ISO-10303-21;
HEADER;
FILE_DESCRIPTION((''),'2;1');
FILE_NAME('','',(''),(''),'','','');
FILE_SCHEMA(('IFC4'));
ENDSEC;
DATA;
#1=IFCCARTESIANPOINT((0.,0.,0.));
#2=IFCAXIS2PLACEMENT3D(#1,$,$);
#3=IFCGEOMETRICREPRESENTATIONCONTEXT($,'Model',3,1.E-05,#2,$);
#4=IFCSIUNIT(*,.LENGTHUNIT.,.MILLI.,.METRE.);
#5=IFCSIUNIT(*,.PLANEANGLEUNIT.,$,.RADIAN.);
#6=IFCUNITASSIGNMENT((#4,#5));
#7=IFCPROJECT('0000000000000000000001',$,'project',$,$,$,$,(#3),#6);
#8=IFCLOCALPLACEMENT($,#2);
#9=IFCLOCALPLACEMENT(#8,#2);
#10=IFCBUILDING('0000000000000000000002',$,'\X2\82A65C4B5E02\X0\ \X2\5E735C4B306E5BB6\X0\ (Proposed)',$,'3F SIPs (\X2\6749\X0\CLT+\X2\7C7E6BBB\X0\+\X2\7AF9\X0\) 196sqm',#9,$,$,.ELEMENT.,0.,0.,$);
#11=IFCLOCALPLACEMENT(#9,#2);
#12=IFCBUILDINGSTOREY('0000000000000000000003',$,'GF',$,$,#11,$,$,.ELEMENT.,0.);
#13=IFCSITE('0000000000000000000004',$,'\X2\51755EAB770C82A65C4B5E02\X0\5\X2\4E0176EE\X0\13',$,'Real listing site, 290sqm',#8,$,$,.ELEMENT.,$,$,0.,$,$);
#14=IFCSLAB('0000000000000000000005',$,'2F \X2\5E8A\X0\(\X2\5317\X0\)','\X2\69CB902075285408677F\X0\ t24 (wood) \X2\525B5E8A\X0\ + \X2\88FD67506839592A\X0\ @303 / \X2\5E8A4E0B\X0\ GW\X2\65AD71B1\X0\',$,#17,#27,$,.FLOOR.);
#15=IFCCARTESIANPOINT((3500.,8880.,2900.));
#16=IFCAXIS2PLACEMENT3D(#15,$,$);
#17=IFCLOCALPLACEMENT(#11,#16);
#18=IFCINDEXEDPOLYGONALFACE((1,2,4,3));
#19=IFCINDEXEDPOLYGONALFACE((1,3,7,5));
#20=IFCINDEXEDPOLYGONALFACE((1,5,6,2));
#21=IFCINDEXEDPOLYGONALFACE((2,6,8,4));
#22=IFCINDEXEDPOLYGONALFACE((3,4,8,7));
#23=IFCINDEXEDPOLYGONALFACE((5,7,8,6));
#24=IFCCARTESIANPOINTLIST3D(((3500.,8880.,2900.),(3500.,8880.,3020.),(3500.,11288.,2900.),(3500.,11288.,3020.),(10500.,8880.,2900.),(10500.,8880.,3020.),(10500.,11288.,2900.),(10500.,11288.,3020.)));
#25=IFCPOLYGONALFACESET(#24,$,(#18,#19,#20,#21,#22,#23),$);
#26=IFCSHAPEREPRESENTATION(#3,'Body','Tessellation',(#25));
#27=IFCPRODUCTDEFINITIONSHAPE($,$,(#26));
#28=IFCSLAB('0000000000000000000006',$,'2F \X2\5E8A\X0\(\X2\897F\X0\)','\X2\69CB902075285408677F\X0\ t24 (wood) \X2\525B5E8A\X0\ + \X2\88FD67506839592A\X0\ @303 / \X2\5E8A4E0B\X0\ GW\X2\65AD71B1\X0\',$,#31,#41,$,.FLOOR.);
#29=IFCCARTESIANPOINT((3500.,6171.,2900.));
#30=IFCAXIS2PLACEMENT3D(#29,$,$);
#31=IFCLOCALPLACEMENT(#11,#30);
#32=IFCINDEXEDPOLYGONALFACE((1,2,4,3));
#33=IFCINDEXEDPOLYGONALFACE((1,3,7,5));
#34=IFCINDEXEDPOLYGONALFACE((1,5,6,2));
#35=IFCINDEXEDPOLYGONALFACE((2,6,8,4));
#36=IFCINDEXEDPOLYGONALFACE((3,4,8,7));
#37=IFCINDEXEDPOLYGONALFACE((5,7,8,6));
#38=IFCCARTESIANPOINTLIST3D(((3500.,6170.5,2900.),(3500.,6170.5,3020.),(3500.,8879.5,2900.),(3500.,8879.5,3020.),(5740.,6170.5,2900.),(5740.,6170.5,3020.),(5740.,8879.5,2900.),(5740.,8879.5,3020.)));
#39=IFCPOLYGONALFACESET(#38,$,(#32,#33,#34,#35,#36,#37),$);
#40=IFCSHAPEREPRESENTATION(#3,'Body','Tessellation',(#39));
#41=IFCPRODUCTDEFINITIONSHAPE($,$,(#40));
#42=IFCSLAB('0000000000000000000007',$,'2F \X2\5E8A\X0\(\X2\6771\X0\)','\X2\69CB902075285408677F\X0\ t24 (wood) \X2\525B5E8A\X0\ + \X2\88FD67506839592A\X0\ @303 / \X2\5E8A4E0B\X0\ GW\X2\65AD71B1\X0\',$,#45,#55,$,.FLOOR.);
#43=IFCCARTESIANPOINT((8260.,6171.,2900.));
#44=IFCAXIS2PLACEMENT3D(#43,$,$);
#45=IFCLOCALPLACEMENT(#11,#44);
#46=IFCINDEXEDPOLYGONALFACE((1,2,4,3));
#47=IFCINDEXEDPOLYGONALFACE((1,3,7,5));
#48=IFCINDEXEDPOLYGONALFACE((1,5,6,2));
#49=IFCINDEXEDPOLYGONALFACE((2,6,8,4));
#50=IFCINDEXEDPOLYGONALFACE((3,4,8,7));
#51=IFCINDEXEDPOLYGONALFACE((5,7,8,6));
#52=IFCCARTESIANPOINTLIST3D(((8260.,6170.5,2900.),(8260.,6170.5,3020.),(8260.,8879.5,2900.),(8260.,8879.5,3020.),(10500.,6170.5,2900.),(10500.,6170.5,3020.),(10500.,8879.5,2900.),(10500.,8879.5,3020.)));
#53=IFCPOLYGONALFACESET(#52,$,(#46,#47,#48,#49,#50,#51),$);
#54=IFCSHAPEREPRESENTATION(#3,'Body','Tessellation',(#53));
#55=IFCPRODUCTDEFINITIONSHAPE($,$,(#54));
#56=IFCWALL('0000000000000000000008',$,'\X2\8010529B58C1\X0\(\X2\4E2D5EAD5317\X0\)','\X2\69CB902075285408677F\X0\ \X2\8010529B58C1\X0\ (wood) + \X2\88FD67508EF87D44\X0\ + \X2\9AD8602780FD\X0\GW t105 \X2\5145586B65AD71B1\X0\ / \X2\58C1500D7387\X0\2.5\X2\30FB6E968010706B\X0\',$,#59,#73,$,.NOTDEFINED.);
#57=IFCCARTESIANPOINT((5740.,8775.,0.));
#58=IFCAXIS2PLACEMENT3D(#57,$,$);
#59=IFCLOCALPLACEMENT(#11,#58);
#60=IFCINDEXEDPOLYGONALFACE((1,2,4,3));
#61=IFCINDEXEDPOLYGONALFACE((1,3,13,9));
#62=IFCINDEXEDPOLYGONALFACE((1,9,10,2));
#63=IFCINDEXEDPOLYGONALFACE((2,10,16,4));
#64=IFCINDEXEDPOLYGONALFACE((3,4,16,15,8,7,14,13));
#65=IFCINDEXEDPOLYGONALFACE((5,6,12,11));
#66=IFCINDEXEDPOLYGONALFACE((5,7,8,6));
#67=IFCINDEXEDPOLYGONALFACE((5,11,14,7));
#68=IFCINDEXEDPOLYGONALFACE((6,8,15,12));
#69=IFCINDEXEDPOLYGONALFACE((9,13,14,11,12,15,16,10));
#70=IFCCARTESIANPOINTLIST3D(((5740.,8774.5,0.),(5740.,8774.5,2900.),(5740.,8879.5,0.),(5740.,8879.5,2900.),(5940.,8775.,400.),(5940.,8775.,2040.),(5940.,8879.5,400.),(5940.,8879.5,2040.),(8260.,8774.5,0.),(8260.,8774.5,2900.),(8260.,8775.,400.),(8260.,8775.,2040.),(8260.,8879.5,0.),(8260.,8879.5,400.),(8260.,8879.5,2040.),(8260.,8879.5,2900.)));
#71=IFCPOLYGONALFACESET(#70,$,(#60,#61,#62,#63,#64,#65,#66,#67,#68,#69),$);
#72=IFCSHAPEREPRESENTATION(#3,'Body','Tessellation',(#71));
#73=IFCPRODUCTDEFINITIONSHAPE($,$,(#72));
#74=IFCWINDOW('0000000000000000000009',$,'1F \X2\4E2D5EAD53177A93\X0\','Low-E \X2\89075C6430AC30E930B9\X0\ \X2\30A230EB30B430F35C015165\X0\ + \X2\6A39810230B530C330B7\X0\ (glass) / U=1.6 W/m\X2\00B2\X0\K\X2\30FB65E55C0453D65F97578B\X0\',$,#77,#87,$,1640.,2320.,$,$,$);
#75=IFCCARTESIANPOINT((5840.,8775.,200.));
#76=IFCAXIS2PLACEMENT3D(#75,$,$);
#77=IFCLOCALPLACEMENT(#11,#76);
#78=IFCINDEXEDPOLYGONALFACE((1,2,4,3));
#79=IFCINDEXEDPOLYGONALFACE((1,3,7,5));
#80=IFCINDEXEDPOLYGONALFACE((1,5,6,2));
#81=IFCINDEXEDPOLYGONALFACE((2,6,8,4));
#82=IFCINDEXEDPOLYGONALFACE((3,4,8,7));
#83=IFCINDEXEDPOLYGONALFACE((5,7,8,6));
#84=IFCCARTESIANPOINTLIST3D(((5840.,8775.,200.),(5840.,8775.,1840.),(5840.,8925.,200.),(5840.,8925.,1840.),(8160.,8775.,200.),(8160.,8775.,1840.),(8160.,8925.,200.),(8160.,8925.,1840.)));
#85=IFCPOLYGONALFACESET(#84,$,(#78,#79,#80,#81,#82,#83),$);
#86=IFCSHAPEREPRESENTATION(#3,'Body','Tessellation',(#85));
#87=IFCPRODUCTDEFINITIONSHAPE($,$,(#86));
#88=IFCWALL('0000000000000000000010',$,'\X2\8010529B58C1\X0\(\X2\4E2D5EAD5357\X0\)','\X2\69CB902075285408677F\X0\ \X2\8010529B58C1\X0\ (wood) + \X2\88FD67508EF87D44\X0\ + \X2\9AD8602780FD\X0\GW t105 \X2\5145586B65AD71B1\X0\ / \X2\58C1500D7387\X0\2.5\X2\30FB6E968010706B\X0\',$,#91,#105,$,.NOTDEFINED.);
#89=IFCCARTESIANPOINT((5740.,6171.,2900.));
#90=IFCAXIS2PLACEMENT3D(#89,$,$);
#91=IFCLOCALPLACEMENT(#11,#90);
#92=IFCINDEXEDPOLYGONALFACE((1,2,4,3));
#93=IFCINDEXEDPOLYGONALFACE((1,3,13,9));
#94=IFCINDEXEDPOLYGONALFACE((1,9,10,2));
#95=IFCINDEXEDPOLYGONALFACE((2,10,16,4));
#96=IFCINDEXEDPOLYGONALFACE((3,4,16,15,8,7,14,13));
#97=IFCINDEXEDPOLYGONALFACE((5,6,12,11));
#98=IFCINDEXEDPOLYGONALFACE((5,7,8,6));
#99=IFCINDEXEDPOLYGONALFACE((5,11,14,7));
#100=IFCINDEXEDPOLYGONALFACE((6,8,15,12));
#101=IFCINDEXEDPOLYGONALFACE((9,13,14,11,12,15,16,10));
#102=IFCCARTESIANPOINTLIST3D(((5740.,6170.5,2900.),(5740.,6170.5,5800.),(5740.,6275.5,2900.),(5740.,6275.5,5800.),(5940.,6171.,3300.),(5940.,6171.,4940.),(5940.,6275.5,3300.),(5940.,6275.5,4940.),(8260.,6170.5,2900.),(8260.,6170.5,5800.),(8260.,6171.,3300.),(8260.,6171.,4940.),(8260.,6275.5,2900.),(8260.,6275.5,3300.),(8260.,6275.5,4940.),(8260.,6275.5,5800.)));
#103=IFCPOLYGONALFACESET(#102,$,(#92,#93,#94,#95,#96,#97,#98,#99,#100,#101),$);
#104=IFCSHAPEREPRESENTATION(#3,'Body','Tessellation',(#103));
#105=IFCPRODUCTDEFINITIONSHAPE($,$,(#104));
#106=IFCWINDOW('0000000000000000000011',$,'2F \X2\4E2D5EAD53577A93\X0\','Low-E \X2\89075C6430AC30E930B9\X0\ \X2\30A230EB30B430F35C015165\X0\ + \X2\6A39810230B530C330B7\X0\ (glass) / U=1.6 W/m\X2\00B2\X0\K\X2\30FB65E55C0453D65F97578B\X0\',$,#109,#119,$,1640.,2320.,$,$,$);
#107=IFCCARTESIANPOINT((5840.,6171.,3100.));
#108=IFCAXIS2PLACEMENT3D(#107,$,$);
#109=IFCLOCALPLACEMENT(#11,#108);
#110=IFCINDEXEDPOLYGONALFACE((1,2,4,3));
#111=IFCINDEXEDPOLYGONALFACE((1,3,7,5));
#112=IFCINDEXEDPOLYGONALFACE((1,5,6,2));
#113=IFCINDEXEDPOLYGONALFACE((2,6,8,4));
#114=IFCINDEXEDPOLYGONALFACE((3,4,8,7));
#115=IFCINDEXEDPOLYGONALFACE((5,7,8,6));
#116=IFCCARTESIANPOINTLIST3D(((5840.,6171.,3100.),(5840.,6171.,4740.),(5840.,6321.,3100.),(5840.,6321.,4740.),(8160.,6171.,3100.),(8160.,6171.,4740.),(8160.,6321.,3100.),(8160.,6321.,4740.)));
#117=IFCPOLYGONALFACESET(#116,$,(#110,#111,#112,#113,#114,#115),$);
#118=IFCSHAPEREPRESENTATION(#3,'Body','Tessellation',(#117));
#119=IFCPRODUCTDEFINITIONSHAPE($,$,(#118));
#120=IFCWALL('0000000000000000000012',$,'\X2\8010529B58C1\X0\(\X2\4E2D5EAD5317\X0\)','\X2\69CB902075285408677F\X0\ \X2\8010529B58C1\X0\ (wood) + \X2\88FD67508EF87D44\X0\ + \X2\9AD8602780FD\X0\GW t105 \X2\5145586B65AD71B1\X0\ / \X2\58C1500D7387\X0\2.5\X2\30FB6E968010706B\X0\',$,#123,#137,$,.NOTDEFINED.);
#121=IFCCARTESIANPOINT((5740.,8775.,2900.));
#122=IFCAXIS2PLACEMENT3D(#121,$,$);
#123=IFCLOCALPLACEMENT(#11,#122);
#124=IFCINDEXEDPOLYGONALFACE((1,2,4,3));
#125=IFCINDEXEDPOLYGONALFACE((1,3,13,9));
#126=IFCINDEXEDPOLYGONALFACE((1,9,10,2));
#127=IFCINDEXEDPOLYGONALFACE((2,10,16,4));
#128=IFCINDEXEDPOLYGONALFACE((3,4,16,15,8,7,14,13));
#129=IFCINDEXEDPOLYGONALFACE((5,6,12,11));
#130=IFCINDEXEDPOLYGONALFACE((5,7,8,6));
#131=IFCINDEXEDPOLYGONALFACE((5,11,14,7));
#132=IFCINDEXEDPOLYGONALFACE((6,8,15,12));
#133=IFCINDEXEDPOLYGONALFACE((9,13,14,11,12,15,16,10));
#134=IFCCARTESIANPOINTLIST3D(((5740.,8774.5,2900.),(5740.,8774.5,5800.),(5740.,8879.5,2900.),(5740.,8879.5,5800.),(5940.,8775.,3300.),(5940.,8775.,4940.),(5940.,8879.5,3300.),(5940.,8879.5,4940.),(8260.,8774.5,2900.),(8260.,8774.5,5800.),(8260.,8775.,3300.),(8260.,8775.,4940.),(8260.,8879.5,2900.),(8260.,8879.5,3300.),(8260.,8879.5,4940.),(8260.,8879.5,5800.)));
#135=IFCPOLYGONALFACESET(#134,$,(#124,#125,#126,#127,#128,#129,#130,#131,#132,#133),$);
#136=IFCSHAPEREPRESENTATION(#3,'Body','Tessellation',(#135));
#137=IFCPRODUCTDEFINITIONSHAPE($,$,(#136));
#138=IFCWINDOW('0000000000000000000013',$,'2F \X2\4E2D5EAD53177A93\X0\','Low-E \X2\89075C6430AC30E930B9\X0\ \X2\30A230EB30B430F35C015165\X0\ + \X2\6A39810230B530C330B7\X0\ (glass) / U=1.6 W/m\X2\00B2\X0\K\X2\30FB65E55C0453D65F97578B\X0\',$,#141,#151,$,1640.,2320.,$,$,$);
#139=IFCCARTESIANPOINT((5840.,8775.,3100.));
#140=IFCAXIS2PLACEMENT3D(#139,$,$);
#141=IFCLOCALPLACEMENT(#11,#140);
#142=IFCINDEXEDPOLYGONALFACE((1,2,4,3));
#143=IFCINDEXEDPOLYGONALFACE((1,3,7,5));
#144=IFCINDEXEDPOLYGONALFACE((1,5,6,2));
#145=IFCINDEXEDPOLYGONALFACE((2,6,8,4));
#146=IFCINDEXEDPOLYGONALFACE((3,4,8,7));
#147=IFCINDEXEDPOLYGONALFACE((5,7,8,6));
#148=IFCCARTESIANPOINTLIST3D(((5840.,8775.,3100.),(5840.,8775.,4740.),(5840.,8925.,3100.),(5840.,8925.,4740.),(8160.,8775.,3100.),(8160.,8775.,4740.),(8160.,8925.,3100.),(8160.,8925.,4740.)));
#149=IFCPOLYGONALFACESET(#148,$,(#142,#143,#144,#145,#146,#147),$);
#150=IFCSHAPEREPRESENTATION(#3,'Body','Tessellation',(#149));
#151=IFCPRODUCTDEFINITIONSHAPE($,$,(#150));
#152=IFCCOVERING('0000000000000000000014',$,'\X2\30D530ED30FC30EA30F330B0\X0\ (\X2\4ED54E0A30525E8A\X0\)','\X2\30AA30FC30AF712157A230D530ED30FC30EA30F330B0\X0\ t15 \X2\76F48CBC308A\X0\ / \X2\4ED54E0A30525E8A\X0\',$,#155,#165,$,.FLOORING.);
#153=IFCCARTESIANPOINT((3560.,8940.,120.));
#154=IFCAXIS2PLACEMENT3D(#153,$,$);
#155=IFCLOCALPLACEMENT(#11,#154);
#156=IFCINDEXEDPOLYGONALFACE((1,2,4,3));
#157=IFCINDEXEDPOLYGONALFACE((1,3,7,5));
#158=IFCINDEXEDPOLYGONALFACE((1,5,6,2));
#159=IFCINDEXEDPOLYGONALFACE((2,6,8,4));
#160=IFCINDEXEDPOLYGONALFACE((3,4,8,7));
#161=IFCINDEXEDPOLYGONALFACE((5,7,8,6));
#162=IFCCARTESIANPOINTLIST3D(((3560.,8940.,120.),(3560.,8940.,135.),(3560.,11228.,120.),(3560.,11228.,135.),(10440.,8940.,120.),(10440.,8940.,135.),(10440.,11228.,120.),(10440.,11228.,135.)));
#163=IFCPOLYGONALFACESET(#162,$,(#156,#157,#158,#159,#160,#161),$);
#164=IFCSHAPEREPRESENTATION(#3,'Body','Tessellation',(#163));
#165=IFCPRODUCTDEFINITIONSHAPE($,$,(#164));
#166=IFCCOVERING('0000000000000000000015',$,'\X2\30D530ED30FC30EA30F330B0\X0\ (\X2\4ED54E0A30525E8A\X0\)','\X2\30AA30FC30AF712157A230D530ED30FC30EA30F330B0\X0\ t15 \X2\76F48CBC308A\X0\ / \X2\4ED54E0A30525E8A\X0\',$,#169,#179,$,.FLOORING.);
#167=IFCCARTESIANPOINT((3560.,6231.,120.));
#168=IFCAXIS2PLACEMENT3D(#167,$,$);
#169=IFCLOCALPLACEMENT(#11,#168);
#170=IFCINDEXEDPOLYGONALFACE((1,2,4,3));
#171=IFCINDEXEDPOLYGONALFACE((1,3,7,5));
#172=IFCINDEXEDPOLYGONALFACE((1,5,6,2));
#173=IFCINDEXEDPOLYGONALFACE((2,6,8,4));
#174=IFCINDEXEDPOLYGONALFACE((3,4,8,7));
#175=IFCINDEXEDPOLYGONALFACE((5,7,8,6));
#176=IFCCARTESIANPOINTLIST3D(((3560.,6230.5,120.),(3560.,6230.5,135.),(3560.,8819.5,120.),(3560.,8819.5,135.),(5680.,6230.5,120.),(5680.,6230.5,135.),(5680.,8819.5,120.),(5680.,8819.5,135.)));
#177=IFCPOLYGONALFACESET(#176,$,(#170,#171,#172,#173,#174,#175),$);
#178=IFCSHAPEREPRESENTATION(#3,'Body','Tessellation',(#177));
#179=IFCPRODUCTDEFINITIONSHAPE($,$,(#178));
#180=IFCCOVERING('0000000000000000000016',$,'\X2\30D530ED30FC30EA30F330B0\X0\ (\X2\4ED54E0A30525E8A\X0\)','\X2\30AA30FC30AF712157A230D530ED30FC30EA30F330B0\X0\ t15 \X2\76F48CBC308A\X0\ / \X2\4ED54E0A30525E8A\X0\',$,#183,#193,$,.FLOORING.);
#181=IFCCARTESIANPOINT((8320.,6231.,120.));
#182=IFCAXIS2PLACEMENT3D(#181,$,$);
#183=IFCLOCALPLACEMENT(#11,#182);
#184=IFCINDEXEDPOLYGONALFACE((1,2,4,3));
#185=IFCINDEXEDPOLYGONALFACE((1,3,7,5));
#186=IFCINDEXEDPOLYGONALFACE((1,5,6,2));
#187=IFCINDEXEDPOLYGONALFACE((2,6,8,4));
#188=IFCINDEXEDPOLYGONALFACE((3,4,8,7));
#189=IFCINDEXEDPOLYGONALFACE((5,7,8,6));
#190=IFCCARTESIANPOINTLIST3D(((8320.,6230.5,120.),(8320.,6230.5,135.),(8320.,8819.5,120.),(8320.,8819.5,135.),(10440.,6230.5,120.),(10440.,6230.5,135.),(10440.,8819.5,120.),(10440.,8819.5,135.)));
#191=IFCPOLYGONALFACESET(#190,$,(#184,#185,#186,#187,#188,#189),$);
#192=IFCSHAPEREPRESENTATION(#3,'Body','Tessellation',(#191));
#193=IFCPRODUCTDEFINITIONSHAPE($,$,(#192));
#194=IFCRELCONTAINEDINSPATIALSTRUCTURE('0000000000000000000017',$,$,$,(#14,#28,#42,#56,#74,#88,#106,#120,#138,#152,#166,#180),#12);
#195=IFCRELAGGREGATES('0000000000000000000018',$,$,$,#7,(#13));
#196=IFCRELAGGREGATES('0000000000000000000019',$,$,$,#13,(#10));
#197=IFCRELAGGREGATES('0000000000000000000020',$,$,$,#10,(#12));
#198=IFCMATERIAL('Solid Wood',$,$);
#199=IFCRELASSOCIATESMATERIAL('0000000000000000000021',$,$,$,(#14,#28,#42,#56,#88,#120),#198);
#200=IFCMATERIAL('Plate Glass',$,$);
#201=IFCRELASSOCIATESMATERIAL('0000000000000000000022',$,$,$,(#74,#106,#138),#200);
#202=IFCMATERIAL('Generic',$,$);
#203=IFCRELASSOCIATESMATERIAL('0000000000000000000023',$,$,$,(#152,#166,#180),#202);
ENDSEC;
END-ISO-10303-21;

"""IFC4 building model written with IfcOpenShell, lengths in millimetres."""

from ifc_helpers import new_model, si_unit, frame, frame_2d, origin, place, context, project, spatial, rectangle, extrude, material, element, fill, save


model = new_model("IFC4")

# Units and contexts
model_context = context("Model", 3, precision=1e-05, world=origin())
ifc_project = project(units=[si_unit("LENGTHUNIT", "METRE", prefix="MILLI"), si_unit("PLANEANGLEUNIT", "RADIAN")], contexts=[model_context])

# Site, building, storey
site_placement = place(None, origin())
site = spatial("IfcSite", under=ifc_project, at=site_placement, Name="兵庫県芦屋市5丁目13", ObjectType="Real listing site, 290sqm", CompositionType="ELEMENT", RefElevation=0.0)
building_placement = place(site_placement, origin())
building = spatial("IfcBuilding", under=site, at=building_placement, Name="芦屋市 平屋の家 (Proposed)", ObjectType="3F SIPs (杉CLT+籾殻+竹) 196sqm", CompositionType="ELEMENT", ElevationOfRefHeight=0.0, ElevationOfTerrain=0.0)
storey_placement = place(building_placement, origin())
storey = spatial("IfcBuildingStorey", under=building, at=storey_placement, Name="GF", CompositionType="ELEMENT", Elevation=0.0)

# Slabs
ifc_material_1 = material(Name="Solid Wood")
slab_1_placement = place(storey_placement, frame((3500.0, 8880.0, 2900.0)))
element("IfcSlab", 1, at=slab_1_placement, inside=storey, material=ifc_material_1, Name="2F 床(北)", Description="構造用合板 t24 (wood) 剛床 + 製材根太 @303 / 床下 GW断熱", PredefinedType="FLOOR", context=model_context, shape_type="SweptSolid", body=[
    extrude(rectangle(XDim=7000.0, YDim=2408.0, at=frame_2d((3500.0, 1204.0))), frame((3500.0, 8880.0, 2900.0)), (0.0, 0.0, 1.0), 120.0),
])
slab_2_placement = place(storey_placement, frame((3500.0, 6171.0, 2900.0)))
element("IfcSlab", 2, at=slab_2_placement, inside=storey, material=ifc_material_1, Name="2F 床(西)", Description="構造用合板 t24 (wood) 剛床 + 製材根太 @303 / 床下 GW断熱", PredefinedType="FLOOR", context=model_context, shape_type="SweptSolid", body=[
    extrude(rectangle(XDim=2240.0, YDim=2709.0, at=frame_2d((1120.0, 1354.0))), frame((3500.0, 6171.0, 2900.0)), (0.0, 0.0, 1.0), 120.0),
])
slab_3_placement = place(storey_placement, frame((8260.0, 6171.0, 2900.0)))
element("IfcSlab", 3, at=slab_3_placement, inside=storey, material=ifc_material_1, Name="2F 床(東)", Description="構造用合板 t24 (wood) 剛床 + 製材根太 @303 / 床下 GW断熱", PredefinedType="FLOOR", context=model_context, shape_type="SweptSolid", body=[
    extrude(rectangle(XDim=2240.0, YDim=2709.0, at=frame_2d((1120.0, 1354.0))), frame((8260.0, 6171.0, 2900.0)), (0.0, 0.0, 1.0), 120.0),
])

# Wall, opening, window
wall_1_placement = place(storey_placement, frame((5740.0, 8775.0, 0.0)))
wall_1 = element("IfcWall", 4, at=wall_1_placement, inside=storey, material=ifc_material_1, Name="耐力壁(中庭北)", Description="構造用合板 耐力壁 (wood) + 製材軸組 + 高性能GW t105 充填断熱 / 壁倍率2.5・準耐火", PredefinedType="NOTDEFINED", context=model_context, shape_type="SweptSolid", body=[
    extrude(rectangle(XDim=2520.0, YDim=105.0, at=frame_2d((1260.0, 52.0))), frame((5740.0, 8775.0, 0.0)), (0.0, 0.0, 1.0), 2900.0),
])
opening_1_placement = place(storey_placement, frame((5840.0, 8775.0, 200.0)))
opening_1 = element("IfcOpeningElement", 5, at=opening_1_placement, cuts=wall_1, PredefinedType="NOTDEFINED", context=model_context, shape_type="SweptSolid", body=[
    extrude(rectangle(XDim=2320.0, YDim=150.0, at=frame_2d((1160.0, 75.0))), frame((5840.0, 8775.0, 200.0)), (0.0, 0.0, 1.0), 1640.0),
])
ifc_material_2 = material(Name="Plate Glass")
window_1_placement = place(storey_placement, frame((5840.0, 8775.0, 200.0)))
window_1 = element("IfcWindow", 6, at=window_1_placement, inside=storey, material=ifc_material_2, Name="1F 中庭北窓", Description="Low-E 複層ガラス アルゴン封入 + 樹脂サッシ (glass) / U=1.6 W/m²K・日射取得型", OverallHeight=1640.0, OverallWidth=2320.0, context=model_context, shape_type="SweptSolid", body=[
    extrude(rectangle(XDim=2320.0, YDim=150.0, at=frame_2d((1160.0, 75.0))), frame((5840.0, 8775.0, 200.0)), (0.0, 0.0, 1.0), 1640.0),
])
fill(opening_1, window_1)

# Walls, openings, windows
wall_2_placement = place(storey_placement, frame((5740.0, 6171.0, 2900.0)))
wall_2 = element("IfcWall", 7, at=wall_2_placement, inside=storey, material=ifc_material_1, Name="耐力壁(中庭南)", Description="構造用合板 耐力壁 (wood) + 製材軸組 + 高性能GW t105 充填断熱 / 壁倍率2.5・準耐火", PredefinedType="NOTDEFINED", context=model_context, shape_type="SweptSolid", body=[
    extrude(rectangle(XDim=2520.0, YDim=105.0, at=frame_2d((1260.0, 52.0))), frame((5740.0, 6171.0, 2900.0)), (0.0, 0.0, 1.0), 2900.0),
])
opening_2_placement = place(storey_placement, frame((5840.0, 6171.0, 3100.0)))
opening_2 = element("IfcOpeningElement", 8, at=opening_2_placement, cuts=wall_2, PredefinedType="NOTDEFINED", context=model_context, shape_type="SweptSolid", body=[
    extrude(rectangle(XDim=2320.0, YDim=150.0, at=frame_2d((1160.0, 75.0))), frame((5840.0, 6171.0, 3100.0)), (0.0, 0.0, 1.0), 1640.0),
])
window_2_placement = place(storey_placement, frame((5840.0, 6171.0, 3100.0)))
window_2 = element("IfcWindow", 9, at=window_2_placement, inside=storey, material=ifc_material_2, Name="2F 中庭南窓", Description="Low-E 複層ガラス アルゴン封入 + 樹脂サッシ (glass) / U=1.6 W/m²K・日射取得型", OverallHeight=1640.0, OverallWidth=2320.0, context=model_context, shape_type="SweptSolid", body=[
    extrude(rectangle(XDim=2320.0, YDim=150.0, at=frame_2d((1160.0, 75.0))), frame((5840.0, 6171.0, 3100.0)), (0.0, 0.0, 1.0), 1640.0),
])
fill(opening_2, window_2)
wall_3_placement = place(storey_placement, frame((5740.0, 8775.0, 2900.0)))
wall_3 = element("IfcWall", 10, at=wall_3_placement, inside=storey, material=ifc_material_1, Name="耐力壁(中庭北)", Description="構造用合板 耐力壁 (wood) + 製材軸組 + 高性能GW t105 充填断熱 / 壁倍率2.5・準耐火", PredefinedType="NOTDEFINED", context=model_context, shape_type="SweptSolid", body=[
    extrude(rectangle(XDim=2520.0, YDim=105.0, at=frame_2d((1260.0, 52.0))), frame((5740.0, 8775.0, 2900.0)), (0.0, 0.0, 1.0), 2900.0),
])
opening_3_placement = place(storey_placement, frame((5840.0, 8775.0, 3100.0)))
opening_3 = element("IfcOpeningElement", 11, at=opening_3_placement, cuts=wall_3, PredefinedType="NOTDEFINED", context=model_context, shape_type="SweptSolid", body=[
    extrude(rectangle(XDim=2320.0, YDim=150.0, at=frame_2d((1160.0, 75.0))), frame((5840.0, 8775.0, 3100.0)), (0.0, 0.0, 1.0), 1640.0),
])
window_3_placement = place(storey_placement, frame((5840.0, 8775.0, 3100.0)))
window_3 = element("IfcWindow", 12, at=window_3_placement, inside=storey, material=ifc_material_2, Name="2F 中庭北窓", Description="Low-E 複層ガラス アルゴン封入 + 樹脂サッシ (glass) / U=1.6 W/m²K・日射取得型", OverallHeight=1640.0, OverallWidth=2320.0, context=model_context, shape_type="SweptSolid", body=[
    extrude(rectangle(XDim=2320.0, YDim=150.0, at=frame_2d((1160.0, 75.0))), frame((5840.0, 8775.0, 3100.0)), (0.0, 0.0, 1.0), 1640.0),
])
fill(opening_3, window_3)

# Coverings
ifc_material_3 = material(Name="Generic")
covering_1_placement = place(storey_placement, frame((3560.0, 8940.0, 120.0)))
element("IfcCovering", 13, at=covering_1_placement, inside=storey, material=ifc_material_3, Name="フローリング (仕上げ床)", Description="オーク無垢フローリング t15 直貼り / 仕上げ床", PredefinedType="FLOORING", context=model_context, shape_type="SweptSolid", body=[
    extrude(rectangle(XDim=6880.0, YDim=2288.0, at=frame_2d((3440.0, 1144.0))), frame((3560.0, 8940.0, 120.0)), (0.0, 0.0, 1.0), 15.0),
])
covering_2_placement = place(storey_placement, frame((3560.0, 6231.0, 120.0)))
element("IfcCovering", 14, at=covering_2_placement, inside=storey, material=ifc_material_3, Name="フローリング (仕上げ床)", Description="オーク無垢フローリング t15 直貼り / 仕上げ床", PredefinedType="FLOORING", context=model_context, shape_type="SweptSolid", body=[
    extrude(rectangle(XDim=2120.0, YDim=2589.0, at=frame_2d((1060.0, 1294.0))), frame((3560.0, 6231.0, 120.0)), (0.0, 0.0, 1.0), 15.0),
])
covering_3_placement = place(storey_placement, frame((8320.0, 6231.0, 120.0)))
element("IfcCovering", 15, at=covering_3_placement, inside=storey, material=ifc_material_3, Name="フローリング (仕上げ床)", Description="オーク無垢フローリング t15 直貼り / 仕上げ床", PredefinedType="FLOORING", context=model_context, shape_type="SweptSolid", body=[
    extrude(rectangle(XDim=2120.0, YDim=2589.0, at=frame_2d((1060.0, 1294.0))), frame((8320.0, 6231.0, 120.0)), (0.0, 0.0, 1.0), 15.0),
])

save(model, "model.ifc")
